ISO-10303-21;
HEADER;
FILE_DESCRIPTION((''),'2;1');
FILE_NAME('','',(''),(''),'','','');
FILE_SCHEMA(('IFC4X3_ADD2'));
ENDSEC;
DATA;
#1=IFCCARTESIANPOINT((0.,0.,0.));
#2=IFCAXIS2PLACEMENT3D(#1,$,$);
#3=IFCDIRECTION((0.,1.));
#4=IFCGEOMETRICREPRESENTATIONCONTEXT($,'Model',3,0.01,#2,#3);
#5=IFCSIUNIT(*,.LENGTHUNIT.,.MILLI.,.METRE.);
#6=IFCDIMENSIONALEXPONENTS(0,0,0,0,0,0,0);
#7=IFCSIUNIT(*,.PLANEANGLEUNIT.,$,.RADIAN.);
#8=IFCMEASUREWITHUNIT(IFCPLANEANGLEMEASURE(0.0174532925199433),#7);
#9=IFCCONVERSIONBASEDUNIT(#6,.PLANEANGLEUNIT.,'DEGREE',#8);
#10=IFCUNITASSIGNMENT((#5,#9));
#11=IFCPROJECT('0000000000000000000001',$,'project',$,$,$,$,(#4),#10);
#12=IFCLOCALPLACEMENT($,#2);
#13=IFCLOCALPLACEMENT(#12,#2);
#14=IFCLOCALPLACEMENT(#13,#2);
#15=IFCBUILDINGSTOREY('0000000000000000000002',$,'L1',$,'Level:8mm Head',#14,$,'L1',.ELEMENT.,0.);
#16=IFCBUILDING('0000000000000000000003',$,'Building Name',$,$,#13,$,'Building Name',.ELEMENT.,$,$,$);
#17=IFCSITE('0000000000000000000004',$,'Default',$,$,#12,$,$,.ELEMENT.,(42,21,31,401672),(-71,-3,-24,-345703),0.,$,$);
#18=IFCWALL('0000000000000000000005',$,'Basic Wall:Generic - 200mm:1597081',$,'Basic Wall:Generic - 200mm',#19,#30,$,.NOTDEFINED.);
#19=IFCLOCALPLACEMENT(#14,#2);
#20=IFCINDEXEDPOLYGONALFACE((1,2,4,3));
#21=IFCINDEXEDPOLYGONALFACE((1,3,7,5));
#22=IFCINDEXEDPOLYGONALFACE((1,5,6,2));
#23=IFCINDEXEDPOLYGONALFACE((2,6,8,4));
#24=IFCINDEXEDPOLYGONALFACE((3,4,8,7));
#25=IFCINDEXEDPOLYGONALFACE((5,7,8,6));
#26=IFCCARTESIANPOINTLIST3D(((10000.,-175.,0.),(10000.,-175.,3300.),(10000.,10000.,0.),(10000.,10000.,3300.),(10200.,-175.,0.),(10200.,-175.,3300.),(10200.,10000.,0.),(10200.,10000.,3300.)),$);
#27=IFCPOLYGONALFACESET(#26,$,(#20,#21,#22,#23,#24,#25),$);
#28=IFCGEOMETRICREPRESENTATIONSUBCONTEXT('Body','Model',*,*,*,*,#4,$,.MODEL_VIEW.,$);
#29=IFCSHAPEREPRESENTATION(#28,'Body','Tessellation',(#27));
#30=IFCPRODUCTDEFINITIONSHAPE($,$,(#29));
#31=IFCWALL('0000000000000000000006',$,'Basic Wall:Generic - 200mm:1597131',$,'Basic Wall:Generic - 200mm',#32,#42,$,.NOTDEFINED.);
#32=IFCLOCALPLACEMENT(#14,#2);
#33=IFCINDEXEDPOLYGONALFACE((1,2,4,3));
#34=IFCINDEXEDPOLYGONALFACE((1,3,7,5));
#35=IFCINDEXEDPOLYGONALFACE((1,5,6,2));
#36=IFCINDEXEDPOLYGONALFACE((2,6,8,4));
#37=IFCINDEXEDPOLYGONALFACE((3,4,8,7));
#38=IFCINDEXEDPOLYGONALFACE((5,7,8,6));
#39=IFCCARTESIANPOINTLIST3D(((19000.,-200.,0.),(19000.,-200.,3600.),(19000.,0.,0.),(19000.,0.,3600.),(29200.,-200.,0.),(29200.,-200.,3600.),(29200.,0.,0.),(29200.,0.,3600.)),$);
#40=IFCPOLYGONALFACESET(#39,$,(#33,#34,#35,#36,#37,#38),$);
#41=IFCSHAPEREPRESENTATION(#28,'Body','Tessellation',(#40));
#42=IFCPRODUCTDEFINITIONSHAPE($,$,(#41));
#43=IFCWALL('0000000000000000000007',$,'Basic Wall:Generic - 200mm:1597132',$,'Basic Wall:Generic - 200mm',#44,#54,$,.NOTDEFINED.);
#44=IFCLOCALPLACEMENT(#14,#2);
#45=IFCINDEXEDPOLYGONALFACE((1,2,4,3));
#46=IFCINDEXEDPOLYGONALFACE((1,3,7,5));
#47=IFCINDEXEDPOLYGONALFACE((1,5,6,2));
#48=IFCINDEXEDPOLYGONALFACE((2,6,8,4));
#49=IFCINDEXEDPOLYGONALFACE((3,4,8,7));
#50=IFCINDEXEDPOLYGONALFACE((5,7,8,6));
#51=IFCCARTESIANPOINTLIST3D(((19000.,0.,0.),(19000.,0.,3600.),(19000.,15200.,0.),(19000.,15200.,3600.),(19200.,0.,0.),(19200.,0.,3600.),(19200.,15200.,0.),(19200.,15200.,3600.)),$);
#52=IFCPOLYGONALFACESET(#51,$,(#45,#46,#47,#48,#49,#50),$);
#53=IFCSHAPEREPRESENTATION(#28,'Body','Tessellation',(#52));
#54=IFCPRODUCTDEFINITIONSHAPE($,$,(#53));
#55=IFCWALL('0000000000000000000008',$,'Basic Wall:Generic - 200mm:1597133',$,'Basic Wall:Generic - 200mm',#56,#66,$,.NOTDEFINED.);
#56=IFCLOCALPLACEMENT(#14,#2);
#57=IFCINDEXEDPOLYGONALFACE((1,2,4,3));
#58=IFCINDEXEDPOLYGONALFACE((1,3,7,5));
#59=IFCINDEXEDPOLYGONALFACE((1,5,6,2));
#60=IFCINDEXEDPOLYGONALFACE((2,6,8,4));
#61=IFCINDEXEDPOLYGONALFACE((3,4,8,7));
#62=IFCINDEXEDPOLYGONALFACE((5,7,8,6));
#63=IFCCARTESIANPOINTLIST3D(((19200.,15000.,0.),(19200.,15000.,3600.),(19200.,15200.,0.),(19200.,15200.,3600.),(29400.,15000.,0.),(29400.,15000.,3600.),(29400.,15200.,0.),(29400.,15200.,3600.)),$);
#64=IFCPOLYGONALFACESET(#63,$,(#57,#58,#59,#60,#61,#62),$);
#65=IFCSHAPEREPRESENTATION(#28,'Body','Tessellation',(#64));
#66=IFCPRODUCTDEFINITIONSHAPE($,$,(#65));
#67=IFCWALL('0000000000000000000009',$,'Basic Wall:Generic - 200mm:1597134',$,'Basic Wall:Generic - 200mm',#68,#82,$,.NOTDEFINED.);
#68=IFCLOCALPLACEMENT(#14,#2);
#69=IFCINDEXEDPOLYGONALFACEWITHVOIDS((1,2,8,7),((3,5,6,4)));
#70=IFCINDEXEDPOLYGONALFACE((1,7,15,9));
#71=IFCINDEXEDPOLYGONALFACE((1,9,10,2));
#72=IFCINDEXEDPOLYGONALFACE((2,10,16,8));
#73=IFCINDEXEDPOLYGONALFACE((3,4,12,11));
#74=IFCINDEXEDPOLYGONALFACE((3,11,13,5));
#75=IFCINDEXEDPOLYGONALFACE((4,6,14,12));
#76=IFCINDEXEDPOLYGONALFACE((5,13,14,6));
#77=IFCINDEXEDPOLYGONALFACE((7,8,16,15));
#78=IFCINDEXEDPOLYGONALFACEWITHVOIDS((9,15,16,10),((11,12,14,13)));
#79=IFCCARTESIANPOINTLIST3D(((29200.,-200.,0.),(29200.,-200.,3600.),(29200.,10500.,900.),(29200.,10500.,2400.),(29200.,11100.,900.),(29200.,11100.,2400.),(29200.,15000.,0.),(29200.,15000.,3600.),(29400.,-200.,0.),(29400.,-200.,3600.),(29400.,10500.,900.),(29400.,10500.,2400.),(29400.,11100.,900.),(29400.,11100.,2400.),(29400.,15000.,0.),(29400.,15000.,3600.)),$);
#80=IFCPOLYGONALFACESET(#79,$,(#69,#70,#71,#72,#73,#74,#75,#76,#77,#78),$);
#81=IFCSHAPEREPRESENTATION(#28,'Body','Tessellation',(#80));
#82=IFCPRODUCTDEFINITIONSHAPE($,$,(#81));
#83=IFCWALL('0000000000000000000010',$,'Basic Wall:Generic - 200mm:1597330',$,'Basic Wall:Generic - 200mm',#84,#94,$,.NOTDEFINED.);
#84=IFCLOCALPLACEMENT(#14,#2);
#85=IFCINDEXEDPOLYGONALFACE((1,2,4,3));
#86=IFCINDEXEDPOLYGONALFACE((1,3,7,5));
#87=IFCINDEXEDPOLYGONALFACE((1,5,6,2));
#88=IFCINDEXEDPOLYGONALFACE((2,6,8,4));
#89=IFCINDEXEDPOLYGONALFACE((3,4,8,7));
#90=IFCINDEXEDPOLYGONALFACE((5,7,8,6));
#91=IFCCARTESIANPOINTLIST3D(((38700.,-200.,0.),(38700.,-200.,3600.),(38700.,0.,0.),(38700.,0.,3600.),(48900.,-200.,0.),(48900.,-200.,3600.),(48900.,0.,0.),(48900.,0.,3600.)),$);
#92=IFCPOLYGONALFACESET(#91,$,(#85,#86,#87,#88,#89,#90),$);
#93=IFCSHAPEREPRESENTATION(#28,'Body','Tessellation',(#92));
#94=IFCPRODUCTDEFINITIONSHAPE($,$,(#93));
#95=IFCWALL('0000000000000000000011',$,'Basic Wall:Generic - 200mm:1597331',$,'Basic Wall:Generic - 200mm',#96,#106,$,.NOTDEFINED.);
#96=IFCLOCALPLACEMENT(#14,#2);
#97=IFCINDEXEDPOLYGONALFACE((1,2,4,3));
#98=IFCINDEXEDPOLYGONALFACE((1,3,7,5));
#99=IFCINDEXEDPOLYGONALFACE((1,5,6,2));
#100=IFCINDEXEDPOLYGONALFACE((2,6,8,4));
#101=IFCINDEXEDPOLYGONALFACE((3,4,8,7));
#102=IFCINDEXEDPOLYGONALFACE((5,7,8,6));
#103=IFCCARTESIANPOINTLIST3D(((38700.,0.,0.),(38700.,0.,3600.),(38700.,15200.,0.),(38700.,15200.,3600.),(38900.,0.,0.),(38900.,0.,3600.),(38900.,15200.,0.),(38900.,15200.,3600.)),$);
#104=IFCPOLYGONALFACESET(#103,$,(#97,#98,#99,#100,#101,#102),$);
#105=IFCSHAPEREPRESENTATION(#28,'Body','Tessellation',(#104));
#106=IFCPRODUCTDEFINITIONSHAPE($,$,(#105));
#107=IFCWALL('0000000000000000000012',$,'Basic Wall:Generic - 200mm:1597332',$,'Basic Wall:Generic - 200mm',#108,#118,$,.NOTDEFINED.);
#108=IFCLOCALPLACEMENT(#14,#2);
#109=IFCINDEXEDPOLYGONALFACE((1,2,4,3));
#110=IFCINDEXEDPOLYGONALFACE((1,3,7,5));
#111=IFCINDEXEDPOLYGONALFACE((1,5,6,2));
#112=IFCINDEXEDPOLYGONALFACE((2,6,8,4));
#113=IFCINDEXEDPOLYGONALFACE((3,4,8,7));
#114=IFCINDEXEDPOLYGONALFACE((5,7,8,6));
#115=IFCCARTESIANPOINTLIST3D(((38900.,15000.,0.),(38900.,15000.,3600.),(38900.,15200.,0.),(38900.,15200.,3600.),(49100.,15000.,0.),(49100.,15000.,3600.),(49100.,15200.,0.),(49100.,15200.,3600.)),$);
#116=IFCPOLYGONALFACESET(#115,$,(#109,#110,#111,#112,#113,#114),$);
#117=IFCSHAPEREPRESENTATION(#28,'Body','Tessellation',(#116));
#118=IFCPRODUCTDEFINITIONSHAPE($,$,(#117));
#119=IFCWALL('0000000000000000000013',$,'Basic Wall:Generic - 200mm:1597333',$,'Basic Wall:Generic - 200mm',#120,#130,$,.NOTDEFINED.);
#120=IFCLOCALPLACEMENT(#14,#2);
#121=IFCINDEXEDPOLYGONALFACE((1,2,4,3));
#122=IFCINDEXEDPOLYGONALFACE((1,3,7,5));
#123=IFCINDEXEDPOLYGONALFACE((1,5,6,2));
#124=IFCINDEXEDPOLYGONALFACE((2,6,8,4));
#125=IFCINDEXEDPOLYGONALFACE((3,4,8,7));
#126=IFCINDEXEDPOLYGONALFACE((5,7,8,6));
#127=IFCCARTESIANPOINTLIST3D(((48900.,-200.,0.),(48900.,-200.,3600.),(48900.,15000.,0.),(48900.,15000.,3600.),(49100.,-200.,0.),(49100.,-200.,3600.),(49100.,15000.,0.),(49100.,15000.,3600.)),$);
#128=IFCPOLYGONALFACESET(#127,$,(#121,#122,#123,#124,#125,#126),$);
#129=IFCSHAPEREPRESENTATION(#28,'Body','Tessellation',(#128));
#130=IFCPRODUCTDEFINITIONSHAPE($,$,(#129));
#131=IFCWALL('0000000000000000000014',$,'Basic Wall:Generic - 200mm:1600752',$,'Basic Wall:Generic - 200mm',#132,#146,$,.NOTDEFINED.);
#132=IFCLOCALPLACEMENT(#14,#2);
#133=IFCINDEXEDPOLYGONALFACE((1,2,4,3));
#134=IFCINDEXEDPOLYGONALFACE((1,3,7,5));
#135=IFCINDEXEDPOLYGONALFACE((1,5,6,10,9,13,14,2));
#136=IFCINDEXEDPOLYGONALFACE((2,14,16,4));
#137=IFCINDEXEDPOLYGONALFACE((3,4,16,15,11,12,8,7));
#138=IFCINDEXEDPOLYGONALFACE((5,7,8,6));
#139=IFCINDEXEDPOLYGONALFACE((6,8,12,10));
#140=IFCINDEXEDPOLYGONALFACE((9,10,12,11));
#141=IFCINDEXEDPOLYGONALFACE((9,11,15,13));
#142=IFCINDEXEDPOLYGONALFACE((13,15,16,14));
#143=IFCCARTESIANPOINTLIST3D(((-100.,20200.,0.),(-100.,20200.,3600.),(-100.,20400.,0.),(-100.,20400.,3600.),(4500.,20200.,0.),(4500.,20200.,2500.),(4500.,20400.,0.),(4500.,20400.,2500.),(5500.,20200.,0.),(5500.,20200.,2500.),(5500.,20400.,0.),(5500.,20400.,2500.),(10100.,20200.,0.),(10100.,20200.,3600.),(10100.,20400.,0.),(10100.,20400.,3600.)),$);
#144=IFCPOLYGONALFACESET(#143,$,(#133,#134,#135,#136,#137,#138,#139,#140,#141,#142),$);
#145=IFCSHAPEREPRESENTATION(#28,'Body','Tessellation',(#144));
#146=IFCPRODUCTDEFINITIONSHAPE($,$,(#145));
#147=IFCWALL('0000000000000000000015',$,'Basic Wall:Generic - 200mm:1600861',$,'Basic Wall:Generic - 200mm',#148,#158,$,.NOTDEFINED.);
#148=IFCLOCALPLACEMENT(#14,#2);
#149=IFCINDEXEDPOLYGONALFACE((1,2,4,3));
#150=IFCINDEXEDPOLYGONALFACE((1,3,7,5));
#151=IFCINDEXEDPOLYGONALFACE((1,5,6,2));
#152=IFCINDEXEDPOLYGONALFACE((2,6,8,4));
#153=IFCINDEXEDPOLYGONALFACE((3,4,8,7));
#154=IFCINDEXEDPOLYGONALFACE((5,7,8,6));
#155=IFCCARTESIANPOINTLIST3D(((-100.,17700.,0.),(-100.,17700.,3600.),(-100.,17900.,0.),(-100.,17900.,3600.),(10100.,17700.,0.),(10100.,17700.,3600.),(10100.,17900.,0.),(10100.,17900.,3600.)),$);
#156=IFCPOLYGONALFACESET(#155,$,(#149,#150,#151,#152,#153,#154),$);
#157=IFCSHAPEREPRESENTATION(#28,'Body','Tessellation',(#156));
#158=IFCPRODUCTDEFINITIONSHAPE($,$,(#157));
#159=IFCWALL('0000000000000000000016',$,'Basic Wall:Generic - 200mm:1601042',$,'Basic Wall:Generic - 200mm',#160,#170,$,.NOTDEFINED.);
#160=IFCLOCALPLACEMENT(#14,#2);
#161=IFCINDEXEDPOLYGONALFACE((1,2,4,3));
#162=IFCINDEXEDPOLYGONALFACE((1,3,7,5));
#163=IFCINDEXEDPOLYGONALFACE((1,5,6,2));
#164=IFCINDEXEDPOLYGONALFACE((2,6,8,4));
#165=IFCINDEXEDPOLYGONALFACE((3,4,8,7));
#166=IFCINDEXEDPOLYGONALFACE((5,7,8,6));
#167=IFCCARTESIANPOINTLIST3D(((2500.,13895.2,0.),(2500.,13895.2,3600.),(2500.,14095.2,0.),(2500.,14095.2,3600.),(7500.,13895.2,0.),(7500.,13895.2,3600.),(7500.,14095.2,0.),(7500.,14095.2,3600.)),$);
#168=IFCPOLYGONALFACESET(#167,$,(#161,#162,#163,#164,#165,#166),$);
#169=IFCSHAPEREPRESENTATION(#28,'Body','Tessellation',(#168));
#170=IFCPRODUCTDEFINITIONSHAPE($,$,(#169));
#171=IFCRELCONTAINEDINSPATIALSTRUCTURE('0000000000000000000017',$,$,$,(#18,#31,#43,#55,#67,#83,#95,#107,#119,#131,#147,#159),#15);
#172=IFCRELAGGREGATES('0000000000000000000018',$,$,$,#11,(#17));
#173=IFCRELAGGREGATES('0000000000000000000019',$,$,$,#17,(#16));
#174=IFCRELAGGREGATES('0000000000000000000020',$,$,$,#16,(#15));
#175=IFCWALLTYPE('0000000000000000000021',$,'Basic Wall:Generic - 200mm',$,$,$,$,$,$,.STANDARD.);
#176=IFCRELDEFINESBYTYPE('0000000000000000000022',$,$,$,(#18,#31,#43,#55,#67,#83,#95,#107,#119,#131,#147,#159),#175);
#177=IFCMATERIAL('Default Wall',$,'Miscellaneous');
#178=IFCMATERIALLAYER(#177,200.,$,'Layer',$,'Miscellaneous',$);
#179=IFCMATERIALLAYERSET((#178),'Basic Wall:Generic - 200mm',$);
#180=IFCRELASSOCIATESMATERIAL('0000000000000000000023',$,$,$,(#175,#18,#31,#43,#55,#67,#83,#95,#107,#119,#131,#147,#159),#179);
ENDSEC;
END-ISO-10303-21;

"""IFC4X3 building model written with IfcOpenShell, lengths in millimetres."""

from ifc_helpers import new_model, entity, si_unit, converted_unit, direction, frame, frame_2d, origin, origin_2d_with_axis, place, context, subcontext, project, spatial, rectangle, extrude, material, layer, layer_set, type_object, element, save


model = new_model("IFC4X3")

# Units and contexts
model_context = context("Model", 3, precision=0.01, world=origin(), true_north=direction((0.0, 1.0)))
body_context = subcontext(model_context, "Body", "Model", "MODEL_VIEW")
ifc_project = project(units=[si_unit("LENGTHUNIT", "METRE", prefix="MILLI"), converted_unit("PLANEANGLEUNIT", "DEGREE", entity("IfcPlaneAngleMeasure", 0.0174532925199433), si_unit("PLANEANGLEUNIT", "RADIAN"), dimensions=[0, 0, 0, 0, 0, 0, 0])], contexts=[model_context])

# Site, building, storey
site_placement = place(None, origin())
site = spatial("IfcSite", under=ifc_project, at=site_placement, Name="Default", CompositionType="ELEMENT", RefLatitude=(42, 21, 31, 401672), RefLongitude=(-71, -3, -24, -345703), RefElevation=0.0)
building_placement = place(site_placement, origin())
building = spatial("IfcBuilding", under=site, at=building_placement, Name="Building Name", LongName="Building Name", CompositionType="ELEMENT")
storey_placement = place(building_placement, origin())
storey = spatial("IfcBuildingStorey", under=building, at=storey_placement, Name="L1", ObjectType="Level:8mm Head", LongName="L1", CompositionType="ELEMENT", Elevation=0.0)

# Walls
ifc_material_1 = material(Name="Default Wall", Category="Miscellaneous")
ifc_layer_1 = layer(ifc_material_1, 200.0, Name="Layer", Category="Miscellaneous")
ifc_layer_set_1 = layer_set([ifc_layer_1], Name="Basic Wall:Generic - 200mm")
wall_type_1 = type_object("IfcWallType", Name="Basic Wall:Generic - 200mm", PredefinedType="STANDARD", material=ifc_layer_set_1)
wall_1_placement = place(storey_placement, frame((10100.0, -175.0, 0.0), z_axis=(0.0, 0.0, 1.0), x_axis=(0.0, 1.0, 0.0)))
element("IfcWall", 1, at=wall_1_placement, inside=storey, type_object=wall_type_1, material=ifc_layer_set_1, Name="Basic Wall:Generic - 200mm:1597081", ObjectType="Basic Wall:Generic - 200mm", PredefinedType="NOTDEFINED", context=body_context, shape_type="SweptSolid", body=[
    extrude(rectangle(XDim=10175.0, YDim=200.0, at=frame_2d((5087.5, 0.0), x_axis=(-1.0, 0.0))), origin(), (0.0, 0.0, 1.0), 3300.0),
])
wall_2_placement = place(storey_placement, frame((19000.0, -100.0, 0.0)))
element("IfcWall", 2, at=wall_2_placement, inside=storey, type_object=wall_type_1, material=ifc_layer_set_1, Name="Basic Wall:Generic - 200mm:1597131", ObjectType="Basic Wall:Generic - 200mm", PredefinedType="NOTDEFINED", context=body_context, shape_type="SweptSolid", body=[
    extrude(rectangle(XDim=10200.0, YDim=200.0, at=frame_2d((5100.0, 0.0), x_axis=(-1.0, 0.0))), origin(), (0.0, 0.0, 1.0), 3600.0),
])
wall_3_placement = place(storey_placement, frame((19100.0, 15200.0, 0.0), z_axis=(0.0, 0.0, 1.0), x_axis=(0.0, -1.0, 0.0)))
element("IfcWall", 3, at=wall_3_placement, inside=storey, type_object=wall_type_1, material=ifc_layer_set_1, Name="Basic Wall:Generic - 200mm:1597132", ObjectType="Basic Wall:Generic - 200mm", PredefinedType="NOTDEFINED", context=body_context, shape_type="SweptSolid", body=[
    extrude(rectangle(XDim=15200.0, YDim=200.0, at=frame_2d((7600.0, 0.0), x_axis=(-1.0, 0.0))), origin(), (0.0, 0.0, 1.0), 3600.0),
])
wall_4_placement = place(storey_placement, frame((29400.0, 15100.0, 0.0), z_axis=(0.0, 0.0, 1.0), x_axis=(-1.0, 0.0, 0.0)))
element("IfcWall", 4, at=wall_4_placement, inside=storey, type_object=wall_type_1, material=ifc_layer_set_1, Name="Basic Wall:Generic - 200mm:1597133", ObjectType="Basic Wall:Generic - 200mm", PredefinedType="NOTDEFINED", context=body_context, shape_type="SweptSolid", body=[
    extrude(rectangle(XDim=10200.0, YDim=200.0, at=frame_2d((5100.0, 0.0), x_axis=(-1.0, 0.0))), origin(), (0.0, 0.0, 1.0), 3600.0),
])

# Wall, opening
wall_5_placement = place(storey_placement, frame((29300.0, -200.0, 0.0), z_axis=(0.0, 0.0, 1.0), x_axis=(0.0, 1.0, 0.0)))
wall_5 = element("IfcWall", 5, at=wall_5_placement, inside=storey, type_object=wall_type_1, material=ifc_layer_set_1, Name="Basic Wall:Generic - 200mm:1597134", ObjectType="Basic Wall:Generic - 200mm", PredefinedType="NOTDEFINED", context=body_context, shape_type="SweptSolid", body=[
    extrude(rectangle(XDim=15200.0, YDim=200.0, at=frame_2d((7600.0, 0.0), x_axis=(-1.0, 0.0))), origin(), (0.0, 0.0, 1.0), 3600.0),
])
opening_1_placement = place(wall_5_placement, frame((11300.0, 100.0, 900.0)))
element("IfcOpeningElement", 6, at=opening_1_placement, cuts=wall_5, PredefinedType="OPENING", context=body_context, shape_type="SweptSolid", body=[
    extrude(rectangle(XDim=1500.0, YDim=600.0, at=frame_2d((750.0, 300.0), x_axis=(-1.0, 0.0))), frame((0.0, 0.0, 0.0), z_axis=(0.0, -1.0, 0.0), x_axis=(0.0, 0.0, 1.0)), (0.0, 0.0, 1.0), 200.0),
])

# Walls
wall_6_placement = place(storey_placement, frame((38700.0, -100.0, 0.0)))
element("IfcWall", 7, at=wall_6_placement, inside=storey, type_object=wall_type_1, material=ifc_layer_set_1, Name="Basic Wall:Generic - 200mm:1597330", ObjectType="Basic Wall:Generic - 200mm", PredefinedType="NOTDEFINED", context=body_context, shape_type="SweptSolid", body=[
    extrude(rectangle(XDim=10200.0, YDim=200.0, at=frame_2d((5100.0, 0.0), x_axis=(-1.0, 0.0))), origin(), (0.0, 0.0, 1.0), 3600.0),
])
wall_7_placement = place(storey_placement, frame((38800.0, 15200.0, 0.0), z_axis=(0.0, 0.0, 1.0), x_axis=(0.0, -1.0, 0.0)))
element("IfcWall", 8, at=wall_7_placement, inside=storey, type_object=wall_type_1, material=ifc_layer_set_1, Name="Basic Wall:Generic - 200mm:1597331", ObjectType="Basic Wall:Generic - 200mm", PredefinedType="NOTDEFINED", context=body_context, shape_type="SweptSolid", body=[
    extrude(rectangle(XDim=15200.0, YDim=200.0, at=frame_2d((7600.0, 0.0), x_axis=(-1.0, 0.0))), origin(), (0.0, 0.0, 1.0), 3600.0),
])
wall_8_placement = place(storey_placement, frame((49100.0, 15100.0, 0.0), z_axis=(0.0, 0.0, 1.0), x_axis=(-1.0, 0.0, 0.0)))
element("IfcWall", 9, at=wall_8_placement, inside=storey, type_object=wall_type_1, material=ifc_layer_set_1, Name="Basic Wall:Generic - 200mm:1597332", ObjectType="Basic Wall:Generic - 200mm", PredefinedType="NOTDEFINED", context=body_context, shape_type="SweptSolid", body=[
    extrude(rectangle(XDim=10200.0, YDim=200.0, at=frame_2d((5100.0, 0.0), x_axis=(-1.0, 0.0))), origin(), (0.0, 0.0, 1.0), 3600.0),
])
wall_9_placement = place(storey_placement, frame((49000.0, -200.0, 0.0), z_axis=(0.0, 0.0, 1.0), x_axis=(0.0, 1.0, 0.0)))
element("IfcWall", 10, at=wall_9_placement, inside=storey, type_object=wall_type_1, material=ifc_layer_set_1, Name="Basic Wall:Generic - 200mm:1597333", ObjectType="Basic Wall:Generic - 200mm", PredefinedType="NOTDEFINED", context=body_context, shape_type="SweptSolid", body=[
    extrude(rectangle(XDim=15200.0, YDim=200.0, at=frame_2d((7600.0, 0.0), x_axis=(-1.0, 0.0))), origin(), (0.0, 0.0, 1.0), 3600.0),
])

# Wall, opening
wall_10_placement = place(storey_placement, frame((10100.0, 20300.0, 0.0), z_axis=(0.0, 0.0, 1.0), x_axis=(-1.0, 0.0, 0.0)))
wall_10 = element("IfcWall", 11, at=wall_10_placement, inside=storey, type_object=wall_type_1, material=ifc_layer_set_1, Name="Basic Wall:Generic - 200mm:1600752", ObjectType="Basic Wall:Generic - 200mm", PredefinedType="NOTDEFINED", context=body_context, shape_type="SweptSolid", body=[
    extrude(rectangle(XDim=10200.0, YDim=200.0, at=frame_2d((5100.0, 0.0), x_axis=(1.0, 0.0))), origin(), (0.0, 0.0, 1.0), 3600.0),
])
opening_2_placement = place(wall_10_placement, frame((5600.0, 100.0, 0.0)))
element("IfcOpeningElement", 12, at=opening_2_placement, cuts=wall_10, PredefinedType="OPENING", context=body_context, shape_type="SweptSolid", body=[
    extrude(rectangle(XDim=2500.0, YDim=1000.0, at=origin_2d_with_axis()), frame((-500.0, -200.0, 1250.0), z_axis=(0.0, 1.0, 0.0), x_axis=(0.0, 0.0, -1.0)), (0.0, 0.0, 1.0), 200.0),
])

# Walls
wall_11_placement = place(storey_placement, frame((10100.0, 17800.0, 0.0), z_axis=(0.0, 0.0, 1.0), x_axis=(-1.0, 0.0, 0.0)))
element("IfcWall", 13, at=wall_11_placement, inside=storey, type_object=wall_type_1, material=ifc_layer_set_1, Name="Basic Wall:Generic - 200mm:1600861", ObjectType="Basic Wall:Generic - 200mm", PredefinedType="NOTDEFINED", context=body_context, shape_type="SweptSolid", body=[
    extrude(rectangle(XDim=10200.0, YDim=200.0, at=frame_2d((5100.0, 0.0), x_axis=(-1.0, 0.0))), origin(), (0.0, 0.0, 1.0), 3600.0),
])
wall_12_placement = place(storey_placement, frame((7500.0, 13995.2, 0.0), z_axis=(0.0, 0.0, 1.0), x_axis=(-1.0, 0.0, 0.0)))
element("IfcWall", 14, at=wall_12_placement, inside=storey, type_object=wall_type_1, material=ifc_layer_set_1, Name="Basic Wall:Generic - 200mm:1601042", ObjectType="Basic Wall:Generic - 200mm", PredefinedType="NOTDEFINED", context=body_context, shape_type="SweptSolid", body=[
    extrude(rectangle(XDim=5000.0, YDim=200.0, at=frame_2d((2500.0, 0.0), x_axis=(-1.0, 0.0))), origin(), (0.0, 0.0, 1.0), 3600.0),
])

save(model, "model.ifc")
